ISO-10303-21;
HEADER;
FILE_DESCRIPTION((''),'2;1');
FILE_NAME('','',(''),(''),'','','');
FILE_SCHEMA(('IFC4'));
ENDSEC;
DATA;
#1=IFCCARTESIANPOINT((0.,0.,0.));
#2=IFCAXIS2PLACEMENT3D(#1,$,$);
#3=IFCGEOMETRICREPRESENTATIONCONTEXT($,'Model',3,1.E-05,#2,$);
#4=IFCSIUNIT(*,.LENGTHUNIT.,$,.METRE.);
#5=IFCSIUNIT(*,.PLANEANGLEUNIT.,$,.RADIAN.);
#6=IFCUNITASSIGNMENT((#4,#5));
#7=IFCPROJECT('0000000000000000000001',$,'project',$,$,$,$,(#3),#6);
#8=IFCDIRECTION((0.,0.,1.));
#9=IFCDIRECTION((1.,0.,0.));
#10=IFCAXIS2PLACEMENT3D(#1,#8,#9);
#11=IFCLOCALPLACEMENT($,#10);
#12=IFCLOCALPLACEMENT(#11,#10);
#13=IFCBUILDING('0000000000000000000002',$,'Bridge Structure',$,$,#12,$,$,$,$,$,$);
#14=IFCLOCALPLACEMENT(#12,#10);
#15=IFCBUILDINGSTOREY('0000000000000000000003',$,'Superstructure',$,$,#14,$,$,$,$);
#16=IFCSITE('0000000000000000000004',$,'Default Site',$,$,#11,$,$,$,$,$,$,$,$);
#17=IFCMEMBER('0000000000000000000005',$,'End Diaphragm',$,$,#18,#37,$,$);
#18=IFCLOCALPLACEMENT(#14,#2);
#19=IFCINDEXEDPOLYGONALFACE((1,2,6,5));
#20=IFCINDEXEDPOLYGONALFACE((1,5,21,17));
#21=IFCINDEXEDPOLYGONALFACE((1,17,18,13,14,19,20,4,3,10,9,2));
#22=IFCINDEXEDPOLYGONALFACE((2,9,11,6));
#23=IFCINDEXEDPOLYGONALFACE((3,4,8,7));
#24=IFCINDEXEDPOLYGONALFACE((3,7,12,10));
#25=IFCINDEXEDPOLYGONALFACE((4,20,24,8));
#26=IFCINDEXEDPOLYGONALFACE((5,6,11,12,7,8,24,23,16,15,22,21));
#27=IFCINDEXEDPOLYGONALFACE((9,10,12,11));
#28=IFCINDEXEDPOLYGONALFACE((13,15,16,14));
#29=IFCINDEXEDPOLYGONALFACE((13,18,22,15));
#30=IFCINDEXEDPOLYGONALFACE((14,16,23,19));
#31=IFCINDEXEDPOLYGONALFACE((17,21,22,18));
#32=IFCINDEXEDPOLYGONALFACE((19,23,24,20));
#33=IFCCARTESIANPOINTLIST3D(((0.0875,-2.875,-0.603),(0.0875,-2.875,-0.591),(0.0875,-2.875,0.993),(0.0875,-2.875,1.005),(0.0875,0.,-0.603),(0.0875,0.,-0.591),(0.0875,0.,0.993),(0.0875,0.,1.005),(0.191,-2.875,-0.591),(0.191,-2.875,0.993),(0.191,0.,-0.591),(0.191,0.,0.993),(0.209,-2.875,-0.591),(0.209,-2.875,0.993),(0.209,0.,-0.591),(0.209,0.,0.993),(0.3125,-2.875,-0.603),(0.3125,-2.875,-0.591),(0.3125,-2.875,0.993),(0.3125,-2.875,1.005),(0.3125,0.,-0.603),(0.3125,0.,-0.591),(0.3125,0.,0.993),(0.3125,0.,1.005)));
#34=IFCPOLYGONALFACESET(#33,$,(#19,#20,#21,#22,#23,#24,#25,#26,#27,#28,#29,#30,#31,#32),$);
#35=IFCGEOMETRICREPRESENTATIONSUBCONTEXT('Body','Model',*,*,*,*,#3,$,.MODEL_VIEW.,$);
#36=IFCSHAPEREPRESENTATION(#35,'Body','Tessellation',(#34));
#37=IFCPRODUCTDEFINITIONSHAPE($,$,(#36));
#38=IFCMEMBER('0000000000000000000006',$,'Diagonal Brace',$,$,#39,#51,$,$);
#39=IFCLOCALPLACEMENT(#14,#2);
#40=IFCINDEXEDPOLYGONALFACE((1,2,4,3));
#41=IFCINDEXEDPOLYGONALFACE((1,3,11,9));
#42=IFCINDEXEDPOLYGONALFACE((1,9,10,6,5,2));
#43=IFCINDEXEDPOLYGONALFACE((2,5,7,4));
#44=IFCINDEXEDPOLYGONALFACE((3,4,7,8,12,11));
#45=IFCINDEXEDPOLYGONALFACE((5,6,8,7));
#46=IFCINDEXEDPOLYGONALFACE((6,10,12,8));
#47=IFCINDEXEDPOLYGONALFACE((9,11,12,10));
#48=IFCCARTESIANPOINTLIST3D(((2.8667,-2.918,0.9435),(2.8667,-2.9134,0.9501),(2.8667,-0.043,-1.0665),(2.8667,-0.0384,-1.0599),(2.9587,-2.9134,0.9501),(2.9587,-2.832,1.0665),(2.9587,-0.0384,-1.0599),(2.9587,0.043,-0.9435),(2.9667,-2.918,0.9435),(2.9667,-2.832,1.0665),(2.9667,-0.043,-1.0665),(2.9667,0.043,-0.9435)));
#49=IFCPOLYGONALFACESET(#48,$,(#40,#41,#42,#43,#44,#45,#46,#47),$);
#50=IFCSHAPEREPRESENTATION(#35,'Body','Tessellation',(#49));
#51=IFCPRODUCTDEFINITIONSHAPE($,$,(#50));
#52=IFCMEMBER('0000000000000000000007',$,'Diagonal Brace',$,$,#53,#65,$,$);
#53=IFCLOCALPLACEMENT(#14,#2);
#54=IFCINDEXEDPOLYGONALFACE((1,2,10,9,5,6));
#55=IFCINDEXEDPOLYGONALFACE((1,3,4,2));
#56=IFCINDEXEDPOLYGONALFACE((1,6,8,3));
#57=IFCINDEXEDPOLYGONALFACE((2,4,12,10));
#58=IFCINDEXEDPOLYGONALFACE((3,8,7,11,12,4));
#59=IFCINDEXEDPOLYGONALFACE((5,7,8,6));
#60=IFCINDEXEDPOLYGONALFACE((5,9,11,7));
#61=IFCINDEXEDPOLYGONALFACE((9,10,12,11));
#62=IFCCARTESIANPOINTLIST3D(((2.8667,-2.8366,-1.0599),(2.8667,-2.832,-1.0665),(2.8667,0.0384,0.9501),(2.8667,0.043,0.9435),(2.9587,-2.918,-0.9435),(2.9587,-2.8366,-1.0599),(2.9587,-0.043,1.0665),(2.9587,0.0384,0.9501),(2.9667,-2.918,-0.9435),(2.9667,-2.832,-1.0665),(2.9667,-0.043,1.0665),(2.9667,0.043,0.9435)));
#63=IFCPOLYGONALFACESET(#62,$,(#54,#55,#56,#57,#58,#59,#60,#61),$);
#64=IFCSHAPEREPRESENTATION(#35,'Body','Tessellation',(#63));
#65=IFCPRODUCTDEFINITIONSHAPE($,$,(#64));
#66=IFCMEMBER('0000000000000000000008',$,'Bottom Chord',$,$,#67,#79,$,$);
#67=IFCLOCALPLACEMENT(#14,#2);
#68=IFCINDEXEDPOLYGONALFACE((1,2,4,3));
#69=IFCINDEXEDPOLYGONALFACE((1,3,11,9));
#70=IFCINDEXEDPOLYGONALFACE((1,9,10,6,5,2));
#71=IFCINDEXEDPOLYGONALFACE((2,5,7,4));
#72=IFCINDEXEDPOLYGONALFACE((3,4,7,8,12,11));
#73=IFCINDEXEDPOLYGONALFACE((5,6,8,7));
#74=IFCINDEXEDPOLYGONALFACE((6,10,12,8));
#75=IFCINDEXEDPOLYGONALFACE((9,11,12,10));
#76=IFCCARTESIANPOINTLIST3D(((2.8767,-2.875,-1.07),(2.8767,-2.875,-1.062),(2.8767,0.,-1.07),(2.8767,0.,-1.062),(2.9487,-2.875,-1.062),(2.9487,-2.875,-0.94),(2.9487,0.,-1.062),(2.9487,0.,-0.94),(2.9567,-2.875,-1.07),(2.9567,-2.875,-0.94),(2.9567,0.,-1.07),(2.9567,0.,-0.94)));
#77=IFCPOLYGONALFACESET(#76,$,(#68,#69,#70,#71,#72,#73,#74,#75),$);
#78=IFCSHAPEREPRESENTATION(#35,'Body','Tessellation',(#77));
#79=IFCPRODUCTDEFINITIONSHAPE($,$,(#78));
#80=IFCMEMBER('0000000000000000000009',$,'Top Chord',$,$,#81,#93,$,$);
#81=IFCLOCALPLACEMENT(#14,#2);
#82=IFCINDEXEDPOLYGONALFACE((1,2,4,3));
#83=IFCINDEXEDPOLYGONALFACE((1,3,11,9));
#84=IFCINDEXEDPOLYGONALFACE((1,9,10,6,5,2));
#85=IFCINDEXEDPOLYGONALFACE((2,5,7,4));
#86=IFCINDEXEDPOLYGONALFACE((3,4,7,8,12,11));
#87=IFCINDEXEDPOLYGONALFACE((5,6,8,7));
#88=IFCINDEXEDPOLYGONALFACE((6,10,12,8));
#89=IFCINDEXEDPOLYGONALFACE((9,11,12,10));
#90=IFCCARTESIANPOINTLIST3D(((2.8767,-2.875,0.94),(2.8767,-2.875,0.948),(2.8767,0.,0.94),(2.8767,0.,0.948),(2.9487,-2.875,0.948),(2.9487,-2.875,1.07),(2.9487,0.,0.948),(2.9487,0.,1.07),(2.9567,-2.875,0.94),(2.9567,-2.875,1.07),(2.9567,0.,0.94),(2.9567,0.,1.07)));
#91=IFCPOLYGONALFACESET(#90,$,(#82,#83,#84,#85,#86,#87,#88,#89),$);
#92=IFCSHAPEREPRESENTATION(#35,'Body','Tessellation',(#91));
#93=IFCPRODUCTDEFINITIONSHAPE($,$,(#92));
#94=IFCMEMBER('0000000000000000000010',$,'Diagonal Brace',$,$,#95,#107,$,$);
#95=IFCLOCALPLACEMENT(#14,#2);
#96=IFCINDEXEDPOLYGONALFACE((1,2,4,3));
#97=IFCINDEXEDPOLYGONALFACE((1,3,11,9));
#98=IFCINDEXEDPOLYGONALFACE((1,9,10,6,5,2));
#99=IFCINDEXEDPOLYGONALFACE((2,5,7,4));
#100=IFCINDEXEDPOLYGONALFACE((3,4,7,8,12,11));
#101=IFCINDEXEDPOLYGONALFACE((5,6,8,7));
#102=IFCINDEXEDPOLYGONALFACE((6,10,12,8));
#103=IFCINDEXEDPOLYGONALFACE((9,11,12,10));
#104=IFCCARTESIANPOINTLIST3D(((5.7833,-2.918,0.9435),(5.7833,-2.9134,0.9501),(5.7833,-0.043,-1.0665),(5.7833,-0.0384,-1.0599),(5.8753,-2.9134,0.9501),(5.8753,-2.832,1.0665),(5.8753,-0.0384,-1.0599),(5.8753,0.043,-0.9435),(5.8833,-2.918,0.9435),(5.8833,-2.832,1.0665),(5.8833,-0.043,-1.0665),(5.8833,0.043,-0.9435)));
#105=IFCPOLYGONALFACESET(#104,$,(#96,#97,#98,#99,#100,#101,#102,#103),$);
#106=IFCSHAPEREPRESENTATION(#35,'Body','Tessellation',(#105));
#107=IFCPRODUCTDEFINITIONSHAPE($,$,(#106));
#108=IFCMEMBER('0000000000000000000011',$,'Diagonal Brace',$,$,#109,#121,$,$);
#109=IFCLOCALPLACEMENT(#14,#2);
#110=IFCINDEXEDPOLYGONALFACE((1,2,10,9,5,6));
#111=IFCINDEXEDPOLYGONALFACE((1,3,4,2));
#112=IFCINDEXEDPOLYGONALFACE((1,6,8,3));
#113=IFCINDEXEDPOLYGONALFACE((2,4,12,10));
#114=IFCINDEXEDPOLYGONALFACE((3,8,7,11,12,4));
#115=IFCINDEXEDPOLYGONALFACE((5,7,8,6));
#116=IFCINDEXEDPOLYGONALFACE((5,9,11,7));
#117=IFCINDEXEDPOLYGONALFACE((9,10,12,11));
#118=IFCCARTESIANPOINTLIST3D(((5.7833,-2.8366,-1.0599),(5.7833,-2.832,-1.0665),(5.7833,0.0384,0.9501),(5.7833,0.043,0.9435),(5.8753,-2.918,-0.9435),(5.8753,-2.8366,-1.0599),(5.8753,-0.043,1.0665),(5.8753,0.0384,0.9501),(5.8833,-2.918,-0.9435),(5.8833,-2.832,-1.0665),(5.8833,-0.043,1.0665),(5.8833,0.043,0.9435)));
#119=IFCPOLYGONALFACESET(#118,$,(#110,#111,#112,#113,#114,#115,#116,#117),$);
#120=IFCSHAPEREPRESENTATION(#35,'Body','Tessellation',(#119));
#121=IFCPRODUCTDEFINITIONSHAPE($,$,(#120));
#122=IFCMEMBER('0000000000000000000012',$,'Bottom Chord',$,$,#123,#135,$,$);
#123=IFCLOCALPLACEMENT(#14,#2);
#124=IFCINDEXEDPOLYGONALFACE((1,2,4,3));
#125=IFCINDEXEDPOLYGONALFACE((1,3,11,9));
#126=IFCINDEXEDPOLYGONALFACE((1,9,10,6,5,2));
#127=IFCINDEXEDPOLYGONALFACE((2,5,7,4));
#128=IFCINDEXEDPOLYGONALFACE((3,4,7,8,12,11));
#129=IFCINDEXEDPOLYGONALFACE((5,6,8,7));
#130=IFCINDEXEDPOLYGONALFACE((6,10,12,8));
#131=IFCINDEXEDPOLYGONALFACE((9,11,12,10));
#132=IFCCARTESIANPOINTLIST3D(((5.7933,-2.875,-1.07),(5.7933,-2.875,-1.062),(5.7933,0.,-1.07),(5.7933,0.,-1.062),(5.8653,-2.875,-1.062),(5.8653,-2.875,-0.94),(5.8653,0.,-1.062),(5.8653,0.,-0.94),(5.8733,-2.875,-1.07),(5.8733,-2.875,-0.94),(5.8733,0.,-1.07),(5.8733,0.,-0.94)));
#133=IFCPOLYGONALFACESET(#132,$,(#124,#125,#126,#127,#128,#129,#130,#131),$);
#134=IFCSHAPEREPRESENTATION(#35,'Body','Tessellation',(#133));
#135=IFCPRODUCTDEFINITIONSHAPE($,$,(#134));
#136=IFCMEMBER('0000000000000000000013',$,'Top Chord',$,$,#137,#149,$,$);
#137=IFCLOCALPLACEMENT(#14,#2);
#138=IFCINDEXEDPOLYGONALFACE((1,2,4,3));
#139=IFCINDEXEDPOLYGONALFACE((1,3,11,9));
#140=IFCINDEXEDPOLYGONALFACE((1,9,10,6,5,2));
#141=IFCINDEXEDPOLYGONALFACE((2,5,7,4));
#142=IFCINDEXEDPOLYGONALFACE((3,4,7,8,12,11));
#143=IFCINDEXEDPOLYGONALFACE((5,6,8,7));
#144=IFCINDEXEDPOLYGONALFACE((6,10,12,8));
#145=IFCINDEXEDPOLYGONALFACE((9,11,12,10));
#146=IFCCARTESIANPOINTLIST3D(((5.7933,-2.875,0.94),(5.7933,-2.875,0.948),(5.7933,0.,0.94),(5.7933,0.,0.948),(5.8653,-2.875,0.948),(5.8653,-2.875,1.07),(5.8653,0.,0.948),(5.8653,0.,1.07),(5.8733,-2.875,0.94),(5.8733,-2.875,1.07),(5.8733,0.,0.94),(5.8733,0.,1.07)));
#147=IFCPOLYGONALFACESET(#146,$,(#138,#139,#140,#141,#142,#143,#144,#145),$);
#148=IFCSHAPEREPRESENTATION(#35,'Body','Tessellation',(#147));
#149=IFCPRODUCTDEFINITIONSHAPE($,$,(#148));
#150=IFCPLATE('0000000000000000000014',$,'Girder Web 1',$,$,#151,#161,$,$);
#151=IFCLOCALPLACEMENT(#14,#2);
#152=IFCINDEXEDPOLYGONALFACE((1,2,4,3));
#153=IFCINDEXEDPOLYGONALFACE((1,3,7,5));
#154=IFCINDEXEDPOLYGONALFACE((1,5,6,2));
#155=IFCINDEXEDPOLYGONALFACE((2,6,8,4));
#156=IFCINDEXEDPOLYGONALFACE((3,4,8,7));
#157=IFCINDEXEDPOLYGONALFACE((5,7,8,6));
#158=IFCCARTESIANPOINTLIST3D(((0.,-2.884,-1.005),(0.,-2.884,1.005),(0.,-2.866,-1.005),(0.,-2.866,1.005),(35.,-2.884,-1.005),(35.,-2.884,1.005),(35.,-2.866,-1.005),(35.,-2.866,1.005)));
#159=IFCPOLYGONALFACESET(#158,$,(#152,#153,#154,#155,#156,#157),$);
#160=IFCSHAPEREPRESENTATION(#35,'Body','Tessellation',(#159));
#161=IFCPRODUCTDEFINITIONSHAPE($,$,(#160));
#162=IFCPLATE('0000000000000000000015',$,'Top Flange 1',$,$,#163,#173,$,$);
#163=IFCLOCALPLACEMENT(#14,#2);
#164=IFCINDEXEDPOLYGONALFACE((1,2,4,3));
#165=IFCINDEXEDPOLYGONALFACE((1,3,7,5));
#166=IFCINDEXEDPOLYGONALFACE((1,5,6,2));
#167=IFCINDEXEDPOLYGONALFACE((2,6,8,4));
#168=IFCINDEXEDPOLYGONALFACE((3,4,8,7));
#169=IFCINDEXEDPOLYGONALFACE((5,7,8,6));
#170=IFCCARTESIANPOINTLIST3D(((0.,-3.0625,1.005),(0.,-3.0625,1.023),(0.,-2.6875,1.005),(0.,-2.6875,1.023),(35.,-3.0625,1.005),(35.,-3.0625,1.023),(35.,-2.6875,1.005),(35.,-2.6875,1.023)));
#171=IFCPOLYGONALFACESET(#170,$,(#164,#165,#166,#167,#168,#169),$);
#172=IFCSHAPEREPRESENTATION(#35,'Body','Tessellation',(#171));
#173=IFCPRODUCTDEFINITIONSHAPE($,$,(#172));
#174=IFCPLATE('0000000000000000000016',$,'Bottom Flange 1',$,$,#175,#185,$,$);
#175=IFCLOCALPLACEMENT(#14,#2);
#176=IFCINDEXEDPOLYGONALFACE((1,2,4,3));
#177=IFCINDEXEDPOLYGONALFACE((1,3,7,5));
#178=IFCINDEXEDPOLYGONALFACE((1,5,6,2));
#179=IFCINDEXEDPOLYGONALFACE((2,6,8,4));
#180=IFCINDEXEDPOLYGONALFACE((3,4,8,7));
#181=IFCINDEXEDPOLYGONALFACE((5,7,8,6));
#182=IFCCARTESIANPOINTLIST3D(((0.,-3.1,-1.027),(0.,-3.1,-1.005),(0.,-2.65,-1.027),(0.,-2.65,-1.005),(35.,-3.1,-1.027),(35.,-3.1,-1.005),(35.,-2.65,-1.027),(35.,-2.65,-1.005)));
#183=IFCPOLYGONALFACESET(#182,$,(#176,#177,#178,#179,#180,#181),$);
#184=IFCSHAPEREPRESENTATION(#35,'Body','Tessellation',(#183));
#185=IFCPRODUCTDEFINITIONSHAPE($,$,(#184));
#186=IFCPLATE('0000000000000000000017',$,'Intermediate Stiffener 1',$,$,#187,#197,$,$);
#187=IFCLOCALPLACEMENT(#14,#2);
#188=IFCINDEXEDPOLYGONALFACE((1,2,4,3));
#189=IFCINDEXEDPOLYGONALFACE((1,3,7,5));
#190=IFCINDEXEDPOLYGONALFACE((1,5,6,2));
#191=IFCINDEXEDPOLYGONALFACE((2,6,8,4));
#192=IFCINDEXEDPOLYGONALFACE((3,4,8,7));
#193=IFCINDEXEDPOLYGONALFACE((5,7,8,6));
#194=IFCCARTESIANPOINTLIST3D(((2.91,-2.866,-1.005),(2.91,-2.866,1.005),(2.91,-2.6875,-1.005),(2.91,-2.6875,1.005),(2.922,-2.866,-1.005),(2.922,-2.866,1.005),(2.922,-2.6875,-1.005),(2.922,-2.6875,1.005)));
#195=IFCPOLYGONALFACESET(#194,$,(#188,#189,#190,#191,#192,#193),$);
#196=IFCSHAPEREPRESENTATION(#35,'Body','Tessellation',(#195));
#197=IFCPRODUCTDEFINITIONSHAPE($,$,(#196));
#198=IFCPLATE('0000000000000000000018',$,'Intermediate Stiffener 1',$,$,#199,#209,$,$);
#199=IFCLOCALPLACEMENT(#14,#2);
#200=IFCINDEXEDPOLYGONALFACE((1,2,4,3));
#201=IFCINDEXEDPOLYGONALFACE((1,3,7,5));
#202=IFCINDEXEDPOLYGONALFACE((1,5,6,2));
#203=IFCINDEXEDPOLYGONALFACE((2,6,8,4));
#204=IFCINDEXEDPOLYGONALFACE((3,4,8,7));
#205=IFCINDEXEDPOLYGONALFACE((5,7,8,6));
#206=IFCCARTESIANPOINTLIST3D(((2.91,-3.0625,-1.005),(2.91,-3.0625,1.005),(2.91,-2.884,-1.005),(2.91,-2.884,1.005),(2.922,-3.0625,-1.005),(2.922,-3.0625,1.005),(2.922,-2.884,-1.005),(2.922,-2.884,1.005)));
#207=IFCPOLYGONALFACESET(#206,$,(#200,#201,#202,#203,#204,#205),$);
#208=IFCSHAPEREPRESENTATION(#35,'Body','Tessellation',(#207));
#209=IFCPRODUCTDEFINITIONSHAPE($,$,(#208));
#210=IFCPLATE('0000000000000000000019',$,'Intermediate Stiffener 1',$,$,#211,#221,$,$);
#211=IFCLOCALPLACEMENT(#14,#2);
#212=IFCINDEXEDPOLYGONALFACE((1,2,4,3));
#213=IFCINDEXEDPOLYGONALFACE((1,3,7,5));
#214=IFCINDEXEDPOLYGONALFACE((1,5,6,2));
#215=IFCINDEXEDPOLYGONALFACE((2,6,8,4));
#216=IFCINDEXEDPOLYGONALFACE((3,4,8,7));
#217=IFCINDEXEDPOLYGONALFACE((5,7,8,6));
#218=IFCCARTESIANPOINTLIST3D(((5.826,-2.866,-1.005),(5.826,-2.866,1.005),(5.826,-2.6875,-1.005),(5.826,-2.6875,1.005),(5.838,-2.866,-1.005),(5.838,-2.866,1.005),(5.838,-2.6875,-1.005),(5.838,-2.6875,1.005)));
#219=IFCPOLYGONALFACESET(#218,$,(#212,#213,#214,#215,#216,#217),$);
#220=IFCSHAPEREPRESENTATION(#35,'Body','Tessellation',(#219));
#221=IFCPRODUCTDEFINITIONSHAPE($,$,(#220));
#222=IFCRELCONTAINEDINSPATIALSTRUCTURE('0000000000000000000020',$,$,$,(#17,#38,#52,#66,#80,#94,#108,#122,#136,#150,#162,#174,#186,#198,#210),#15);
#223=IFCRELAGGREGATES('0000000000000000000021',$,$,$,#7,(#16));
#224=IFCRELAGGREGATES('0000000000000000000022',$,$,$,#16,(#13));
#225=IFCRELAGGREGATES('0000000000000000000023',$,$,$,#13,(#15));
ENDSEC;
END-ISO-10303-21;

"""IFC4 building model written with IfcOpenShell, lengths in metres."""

from ifc_helpers import new_model, si_unit, frame, origin, origin_with_axes, origin_2d_with_axis, place, context, subcontext, project, spatial, rectangle, i_section, l_section, extrude, element, save


model = new_model("IFC4")

# Units and contexts
model_context = context("Model", 3, precision=1e-05, world=origin())
body_context = subcontext(model_context, "Body", "Model", "MODEL_VIEW")
ifc_project = project(units=[si_unit("LENGTHUNIT", "METRE"), si_unit("PLANEANGLEUNIT", "RADIAN")], contexts=[model_context])

# Site, building, storey
site_placement = place(None, origin_with_axes())
site = spatial("IfcSite", under=ifc_project, at=site_placement, Name="Default Site")
building_placement = place(site_placement, origin_with_axes())
building = spatial("IfcBuilding", under=site, at=building_placement, Name="Bridge Structure")
storey_placement = place(building_placement, origin_with_axes())
storey = spatial("IfcBuildingStorey", under=building, at=storey_placement, Name="Superstructure")

# Members
member_placement = place(storey_placement, frame((0.2, -2.875, 0.201), z_axis=(0.0, 1.0, 0.0), x_axis=(-1.0, 0.0, 0.0)))
element("IfcMember", 1, at=member_placement, inside=storey, Name="End Diaphragm", context=body_context, shape_type="SweptSolid", body=[
    extrude(i_section(OverallWidth=0.225, OverallDepth=1.608, WebThickness=0.018, FlangeThickness=0.012, at=origin_2d_with_axis()), origin_with_axes(), (0.0, 0.0, 1.0), 2.875),
])
for number, where, z_axis, x_axis, name in (
    (2, (2.9167, -2.875, 1.005), (0.0, 0.819567, -0.572984), (-1.0, 0.0, 0.0), "Diagonal Brace"),
    (3, (2.9167, -2.875, -1.005), (0.0, 0.819567, 0.572984), (-1.0, 0.0, 0.0), "Diagonal Brace"),
):
    element("IfcMember", number, at=place(storey_placement, frame(where, z_axis=z_axis, x_axis=x_axis)), inside=storey, Name=name, context=body_context, shape_type="SweptSolid", body=[
        extrude(l_section(Depth=0.15, Width=0.1, Thickness=0.008, at=origin_2d_with_axis()), origin_with_axes(), (0.0, 0.0, 1.0), 3.508),
    ])
for number, where, z_axis, x_axis, name in (
    (4, (2.9167, -2.875, -1.005), (0.0, 1.0, 0.0), (-1.0, 0.0, 0.0), "Bottom Chord"),
    (5, (2.9167, -2.875, 1.005), (0.0, 1.0, 0.0), (-1.0, 0.0, 0.0), "Top Chord"),
):
    element("IfcMember", number, at=place(storey_placement, frame(where, z_axis=z_axis, x_axis=x_axis)), inside=storey, Name=name, context=body_context, shape_type="SweptSolid", body=[
        extrude(l_section(Depth=0.13, Width=0.08, Thickness=0.008, at=origin_2d_with_axis()), origin_with_axes(), (0.0, 0.0, 1.0), 2.875),
    ])
for number, where, z_axis, x_axis, name in (
    (6, (5.8333, -2.875, 1.005), (0.0, 0.819567, -0.572984), (-1.0, 0.0, 0.0), "Diagonal Brace"),
    (7, (5.8333, -2.875, -1.005), (0.0, 0.819567, 0.572984), (-1.0, 0.0, 0.0), "Diagonal Brace"),
):
    element("IfcMember", number, at=place(storey_placement, frame(where, z_axis=z_axis, x_axis=x_axis)), inside=storey, Name=name, context=body_context, shape_type="SweptSolid", body=[
        extrude(l_section(Depth=0.15, Width=0.1, Thickness=0.008, at=origin_2d_with_axis()), origin_with_axes(), (0.0, 0.0, 1.0), 3.508),
    ])
for number, where, z_axis, x_axis, name in (
    (8, (5.8333, -2.875, -1.005), (0.0, 1.0, 0.0), (-1.0, 0.0, 0.0), "Bottom Chord"),
    (9, (5.8333, -2.875, 1.005), (0.0, 1.0, 0.0), (-1.0, 0.0, 0.0), "Top Chord"),
):
    element("IfcMember", number, at=place(storey_placement, frame(where, z_axis=z_axis, x_axis=x_axis)), inside=storey, Name=name, context=body_context, shape_type="SweptSolid", body=[
        extrude(l_section(Depth=0.13, Width=0.08, Thickness=0.008, at=origin_2d_with_axis()), origin_with_axes(), (0.0, 0.0, 1.0), 2.875),
    ])

# Plates
plate_1_placement = place(storey_placement, frame((0.0, -2.875, 0.0), z_axis=(1.0, 0.0, 0.0), x_axis=(0.0, 1.0, 0.0)))
element("IfcPlate", 10, at=plate_1_placement, inside=storey, Name="Girder Web 1", context=body_context, shape_type="SweptSolid", body=[
    extrude(rectangle(XDim=0.018, YDim=2.01, at=origin_2d_with_axis()), origin_with_axes(), (0.0, 0.0, 1.0), 35.0),
])
plate_2_placement = place(storey_placement, frame((0.0, -2.875, 1.014), z_axis=(1.0, 0.0, 0.0), x_axis=(0.0, 1.0, 0.0)))
element("IfcPlate", 11, at=plate_2_placement, inside=storey, Name="Top Flange 1", context=body_context, shape_type="SweptSolid", body=[
    extrude(rectangle(XDim=0.375, YDim=0.018, at=origin_2d_with_axis()), origin_with_axes(), (0.0, 0.0, 1.0), 35.0),
])
plate_3_placement = place(storey_placement, frame((0.0, -2.875, -1.016), z_axis=(1.0, 0.0, 0.0), x_axis=(0.0, 1.0, 0.0)))
element("IfcPlate", 12, at=plate_3_placement, inside=storey, Name="Bottom Flange 1", context=body_context, shape_type="SweptSolid", body=[
    extrude(rectangle(XDim=0.45, YDim=0.022, at=origin_2d_with_axis()), origin_with_axes(), (0.0, 0.0, 1.0), 35.0),
])
for number, where, z_axis, x_axis, name in (
    (13, (2.916, -2.7768, -1.005), (0.0, 0.0, 1.0), (1.0, 0.0, 0.0), "Intermediate Stiffener 1"),
    (14, (2.916, -2.9733, -1.005), (0.0, 0.0, 1.0), (1.0, 0.0, 0.0), "Intermediate Stiffener 1"),
    (15, (5.832, -2.7768, -1.005), (0.0, 0.0, 1.0), (1.0, 0.0, 0.0), "Intermediate Stiffener 1"),
):
    element("IfcPlate", number, at=place(storey_placement, frame(where, z_axis=z_axis, x_axis=x_axis)), inside=storey, Name=name, context=body_context, shape_type="SweptSolid", body=[
        extrude(rectangle(XDim=0.012, YDim=0.1785, at=origin_2d_with_axis()), origin_with_axes(), (0.0, 0.0, 1.0), 2.01),
    ])

save(model, "model.ifc")
